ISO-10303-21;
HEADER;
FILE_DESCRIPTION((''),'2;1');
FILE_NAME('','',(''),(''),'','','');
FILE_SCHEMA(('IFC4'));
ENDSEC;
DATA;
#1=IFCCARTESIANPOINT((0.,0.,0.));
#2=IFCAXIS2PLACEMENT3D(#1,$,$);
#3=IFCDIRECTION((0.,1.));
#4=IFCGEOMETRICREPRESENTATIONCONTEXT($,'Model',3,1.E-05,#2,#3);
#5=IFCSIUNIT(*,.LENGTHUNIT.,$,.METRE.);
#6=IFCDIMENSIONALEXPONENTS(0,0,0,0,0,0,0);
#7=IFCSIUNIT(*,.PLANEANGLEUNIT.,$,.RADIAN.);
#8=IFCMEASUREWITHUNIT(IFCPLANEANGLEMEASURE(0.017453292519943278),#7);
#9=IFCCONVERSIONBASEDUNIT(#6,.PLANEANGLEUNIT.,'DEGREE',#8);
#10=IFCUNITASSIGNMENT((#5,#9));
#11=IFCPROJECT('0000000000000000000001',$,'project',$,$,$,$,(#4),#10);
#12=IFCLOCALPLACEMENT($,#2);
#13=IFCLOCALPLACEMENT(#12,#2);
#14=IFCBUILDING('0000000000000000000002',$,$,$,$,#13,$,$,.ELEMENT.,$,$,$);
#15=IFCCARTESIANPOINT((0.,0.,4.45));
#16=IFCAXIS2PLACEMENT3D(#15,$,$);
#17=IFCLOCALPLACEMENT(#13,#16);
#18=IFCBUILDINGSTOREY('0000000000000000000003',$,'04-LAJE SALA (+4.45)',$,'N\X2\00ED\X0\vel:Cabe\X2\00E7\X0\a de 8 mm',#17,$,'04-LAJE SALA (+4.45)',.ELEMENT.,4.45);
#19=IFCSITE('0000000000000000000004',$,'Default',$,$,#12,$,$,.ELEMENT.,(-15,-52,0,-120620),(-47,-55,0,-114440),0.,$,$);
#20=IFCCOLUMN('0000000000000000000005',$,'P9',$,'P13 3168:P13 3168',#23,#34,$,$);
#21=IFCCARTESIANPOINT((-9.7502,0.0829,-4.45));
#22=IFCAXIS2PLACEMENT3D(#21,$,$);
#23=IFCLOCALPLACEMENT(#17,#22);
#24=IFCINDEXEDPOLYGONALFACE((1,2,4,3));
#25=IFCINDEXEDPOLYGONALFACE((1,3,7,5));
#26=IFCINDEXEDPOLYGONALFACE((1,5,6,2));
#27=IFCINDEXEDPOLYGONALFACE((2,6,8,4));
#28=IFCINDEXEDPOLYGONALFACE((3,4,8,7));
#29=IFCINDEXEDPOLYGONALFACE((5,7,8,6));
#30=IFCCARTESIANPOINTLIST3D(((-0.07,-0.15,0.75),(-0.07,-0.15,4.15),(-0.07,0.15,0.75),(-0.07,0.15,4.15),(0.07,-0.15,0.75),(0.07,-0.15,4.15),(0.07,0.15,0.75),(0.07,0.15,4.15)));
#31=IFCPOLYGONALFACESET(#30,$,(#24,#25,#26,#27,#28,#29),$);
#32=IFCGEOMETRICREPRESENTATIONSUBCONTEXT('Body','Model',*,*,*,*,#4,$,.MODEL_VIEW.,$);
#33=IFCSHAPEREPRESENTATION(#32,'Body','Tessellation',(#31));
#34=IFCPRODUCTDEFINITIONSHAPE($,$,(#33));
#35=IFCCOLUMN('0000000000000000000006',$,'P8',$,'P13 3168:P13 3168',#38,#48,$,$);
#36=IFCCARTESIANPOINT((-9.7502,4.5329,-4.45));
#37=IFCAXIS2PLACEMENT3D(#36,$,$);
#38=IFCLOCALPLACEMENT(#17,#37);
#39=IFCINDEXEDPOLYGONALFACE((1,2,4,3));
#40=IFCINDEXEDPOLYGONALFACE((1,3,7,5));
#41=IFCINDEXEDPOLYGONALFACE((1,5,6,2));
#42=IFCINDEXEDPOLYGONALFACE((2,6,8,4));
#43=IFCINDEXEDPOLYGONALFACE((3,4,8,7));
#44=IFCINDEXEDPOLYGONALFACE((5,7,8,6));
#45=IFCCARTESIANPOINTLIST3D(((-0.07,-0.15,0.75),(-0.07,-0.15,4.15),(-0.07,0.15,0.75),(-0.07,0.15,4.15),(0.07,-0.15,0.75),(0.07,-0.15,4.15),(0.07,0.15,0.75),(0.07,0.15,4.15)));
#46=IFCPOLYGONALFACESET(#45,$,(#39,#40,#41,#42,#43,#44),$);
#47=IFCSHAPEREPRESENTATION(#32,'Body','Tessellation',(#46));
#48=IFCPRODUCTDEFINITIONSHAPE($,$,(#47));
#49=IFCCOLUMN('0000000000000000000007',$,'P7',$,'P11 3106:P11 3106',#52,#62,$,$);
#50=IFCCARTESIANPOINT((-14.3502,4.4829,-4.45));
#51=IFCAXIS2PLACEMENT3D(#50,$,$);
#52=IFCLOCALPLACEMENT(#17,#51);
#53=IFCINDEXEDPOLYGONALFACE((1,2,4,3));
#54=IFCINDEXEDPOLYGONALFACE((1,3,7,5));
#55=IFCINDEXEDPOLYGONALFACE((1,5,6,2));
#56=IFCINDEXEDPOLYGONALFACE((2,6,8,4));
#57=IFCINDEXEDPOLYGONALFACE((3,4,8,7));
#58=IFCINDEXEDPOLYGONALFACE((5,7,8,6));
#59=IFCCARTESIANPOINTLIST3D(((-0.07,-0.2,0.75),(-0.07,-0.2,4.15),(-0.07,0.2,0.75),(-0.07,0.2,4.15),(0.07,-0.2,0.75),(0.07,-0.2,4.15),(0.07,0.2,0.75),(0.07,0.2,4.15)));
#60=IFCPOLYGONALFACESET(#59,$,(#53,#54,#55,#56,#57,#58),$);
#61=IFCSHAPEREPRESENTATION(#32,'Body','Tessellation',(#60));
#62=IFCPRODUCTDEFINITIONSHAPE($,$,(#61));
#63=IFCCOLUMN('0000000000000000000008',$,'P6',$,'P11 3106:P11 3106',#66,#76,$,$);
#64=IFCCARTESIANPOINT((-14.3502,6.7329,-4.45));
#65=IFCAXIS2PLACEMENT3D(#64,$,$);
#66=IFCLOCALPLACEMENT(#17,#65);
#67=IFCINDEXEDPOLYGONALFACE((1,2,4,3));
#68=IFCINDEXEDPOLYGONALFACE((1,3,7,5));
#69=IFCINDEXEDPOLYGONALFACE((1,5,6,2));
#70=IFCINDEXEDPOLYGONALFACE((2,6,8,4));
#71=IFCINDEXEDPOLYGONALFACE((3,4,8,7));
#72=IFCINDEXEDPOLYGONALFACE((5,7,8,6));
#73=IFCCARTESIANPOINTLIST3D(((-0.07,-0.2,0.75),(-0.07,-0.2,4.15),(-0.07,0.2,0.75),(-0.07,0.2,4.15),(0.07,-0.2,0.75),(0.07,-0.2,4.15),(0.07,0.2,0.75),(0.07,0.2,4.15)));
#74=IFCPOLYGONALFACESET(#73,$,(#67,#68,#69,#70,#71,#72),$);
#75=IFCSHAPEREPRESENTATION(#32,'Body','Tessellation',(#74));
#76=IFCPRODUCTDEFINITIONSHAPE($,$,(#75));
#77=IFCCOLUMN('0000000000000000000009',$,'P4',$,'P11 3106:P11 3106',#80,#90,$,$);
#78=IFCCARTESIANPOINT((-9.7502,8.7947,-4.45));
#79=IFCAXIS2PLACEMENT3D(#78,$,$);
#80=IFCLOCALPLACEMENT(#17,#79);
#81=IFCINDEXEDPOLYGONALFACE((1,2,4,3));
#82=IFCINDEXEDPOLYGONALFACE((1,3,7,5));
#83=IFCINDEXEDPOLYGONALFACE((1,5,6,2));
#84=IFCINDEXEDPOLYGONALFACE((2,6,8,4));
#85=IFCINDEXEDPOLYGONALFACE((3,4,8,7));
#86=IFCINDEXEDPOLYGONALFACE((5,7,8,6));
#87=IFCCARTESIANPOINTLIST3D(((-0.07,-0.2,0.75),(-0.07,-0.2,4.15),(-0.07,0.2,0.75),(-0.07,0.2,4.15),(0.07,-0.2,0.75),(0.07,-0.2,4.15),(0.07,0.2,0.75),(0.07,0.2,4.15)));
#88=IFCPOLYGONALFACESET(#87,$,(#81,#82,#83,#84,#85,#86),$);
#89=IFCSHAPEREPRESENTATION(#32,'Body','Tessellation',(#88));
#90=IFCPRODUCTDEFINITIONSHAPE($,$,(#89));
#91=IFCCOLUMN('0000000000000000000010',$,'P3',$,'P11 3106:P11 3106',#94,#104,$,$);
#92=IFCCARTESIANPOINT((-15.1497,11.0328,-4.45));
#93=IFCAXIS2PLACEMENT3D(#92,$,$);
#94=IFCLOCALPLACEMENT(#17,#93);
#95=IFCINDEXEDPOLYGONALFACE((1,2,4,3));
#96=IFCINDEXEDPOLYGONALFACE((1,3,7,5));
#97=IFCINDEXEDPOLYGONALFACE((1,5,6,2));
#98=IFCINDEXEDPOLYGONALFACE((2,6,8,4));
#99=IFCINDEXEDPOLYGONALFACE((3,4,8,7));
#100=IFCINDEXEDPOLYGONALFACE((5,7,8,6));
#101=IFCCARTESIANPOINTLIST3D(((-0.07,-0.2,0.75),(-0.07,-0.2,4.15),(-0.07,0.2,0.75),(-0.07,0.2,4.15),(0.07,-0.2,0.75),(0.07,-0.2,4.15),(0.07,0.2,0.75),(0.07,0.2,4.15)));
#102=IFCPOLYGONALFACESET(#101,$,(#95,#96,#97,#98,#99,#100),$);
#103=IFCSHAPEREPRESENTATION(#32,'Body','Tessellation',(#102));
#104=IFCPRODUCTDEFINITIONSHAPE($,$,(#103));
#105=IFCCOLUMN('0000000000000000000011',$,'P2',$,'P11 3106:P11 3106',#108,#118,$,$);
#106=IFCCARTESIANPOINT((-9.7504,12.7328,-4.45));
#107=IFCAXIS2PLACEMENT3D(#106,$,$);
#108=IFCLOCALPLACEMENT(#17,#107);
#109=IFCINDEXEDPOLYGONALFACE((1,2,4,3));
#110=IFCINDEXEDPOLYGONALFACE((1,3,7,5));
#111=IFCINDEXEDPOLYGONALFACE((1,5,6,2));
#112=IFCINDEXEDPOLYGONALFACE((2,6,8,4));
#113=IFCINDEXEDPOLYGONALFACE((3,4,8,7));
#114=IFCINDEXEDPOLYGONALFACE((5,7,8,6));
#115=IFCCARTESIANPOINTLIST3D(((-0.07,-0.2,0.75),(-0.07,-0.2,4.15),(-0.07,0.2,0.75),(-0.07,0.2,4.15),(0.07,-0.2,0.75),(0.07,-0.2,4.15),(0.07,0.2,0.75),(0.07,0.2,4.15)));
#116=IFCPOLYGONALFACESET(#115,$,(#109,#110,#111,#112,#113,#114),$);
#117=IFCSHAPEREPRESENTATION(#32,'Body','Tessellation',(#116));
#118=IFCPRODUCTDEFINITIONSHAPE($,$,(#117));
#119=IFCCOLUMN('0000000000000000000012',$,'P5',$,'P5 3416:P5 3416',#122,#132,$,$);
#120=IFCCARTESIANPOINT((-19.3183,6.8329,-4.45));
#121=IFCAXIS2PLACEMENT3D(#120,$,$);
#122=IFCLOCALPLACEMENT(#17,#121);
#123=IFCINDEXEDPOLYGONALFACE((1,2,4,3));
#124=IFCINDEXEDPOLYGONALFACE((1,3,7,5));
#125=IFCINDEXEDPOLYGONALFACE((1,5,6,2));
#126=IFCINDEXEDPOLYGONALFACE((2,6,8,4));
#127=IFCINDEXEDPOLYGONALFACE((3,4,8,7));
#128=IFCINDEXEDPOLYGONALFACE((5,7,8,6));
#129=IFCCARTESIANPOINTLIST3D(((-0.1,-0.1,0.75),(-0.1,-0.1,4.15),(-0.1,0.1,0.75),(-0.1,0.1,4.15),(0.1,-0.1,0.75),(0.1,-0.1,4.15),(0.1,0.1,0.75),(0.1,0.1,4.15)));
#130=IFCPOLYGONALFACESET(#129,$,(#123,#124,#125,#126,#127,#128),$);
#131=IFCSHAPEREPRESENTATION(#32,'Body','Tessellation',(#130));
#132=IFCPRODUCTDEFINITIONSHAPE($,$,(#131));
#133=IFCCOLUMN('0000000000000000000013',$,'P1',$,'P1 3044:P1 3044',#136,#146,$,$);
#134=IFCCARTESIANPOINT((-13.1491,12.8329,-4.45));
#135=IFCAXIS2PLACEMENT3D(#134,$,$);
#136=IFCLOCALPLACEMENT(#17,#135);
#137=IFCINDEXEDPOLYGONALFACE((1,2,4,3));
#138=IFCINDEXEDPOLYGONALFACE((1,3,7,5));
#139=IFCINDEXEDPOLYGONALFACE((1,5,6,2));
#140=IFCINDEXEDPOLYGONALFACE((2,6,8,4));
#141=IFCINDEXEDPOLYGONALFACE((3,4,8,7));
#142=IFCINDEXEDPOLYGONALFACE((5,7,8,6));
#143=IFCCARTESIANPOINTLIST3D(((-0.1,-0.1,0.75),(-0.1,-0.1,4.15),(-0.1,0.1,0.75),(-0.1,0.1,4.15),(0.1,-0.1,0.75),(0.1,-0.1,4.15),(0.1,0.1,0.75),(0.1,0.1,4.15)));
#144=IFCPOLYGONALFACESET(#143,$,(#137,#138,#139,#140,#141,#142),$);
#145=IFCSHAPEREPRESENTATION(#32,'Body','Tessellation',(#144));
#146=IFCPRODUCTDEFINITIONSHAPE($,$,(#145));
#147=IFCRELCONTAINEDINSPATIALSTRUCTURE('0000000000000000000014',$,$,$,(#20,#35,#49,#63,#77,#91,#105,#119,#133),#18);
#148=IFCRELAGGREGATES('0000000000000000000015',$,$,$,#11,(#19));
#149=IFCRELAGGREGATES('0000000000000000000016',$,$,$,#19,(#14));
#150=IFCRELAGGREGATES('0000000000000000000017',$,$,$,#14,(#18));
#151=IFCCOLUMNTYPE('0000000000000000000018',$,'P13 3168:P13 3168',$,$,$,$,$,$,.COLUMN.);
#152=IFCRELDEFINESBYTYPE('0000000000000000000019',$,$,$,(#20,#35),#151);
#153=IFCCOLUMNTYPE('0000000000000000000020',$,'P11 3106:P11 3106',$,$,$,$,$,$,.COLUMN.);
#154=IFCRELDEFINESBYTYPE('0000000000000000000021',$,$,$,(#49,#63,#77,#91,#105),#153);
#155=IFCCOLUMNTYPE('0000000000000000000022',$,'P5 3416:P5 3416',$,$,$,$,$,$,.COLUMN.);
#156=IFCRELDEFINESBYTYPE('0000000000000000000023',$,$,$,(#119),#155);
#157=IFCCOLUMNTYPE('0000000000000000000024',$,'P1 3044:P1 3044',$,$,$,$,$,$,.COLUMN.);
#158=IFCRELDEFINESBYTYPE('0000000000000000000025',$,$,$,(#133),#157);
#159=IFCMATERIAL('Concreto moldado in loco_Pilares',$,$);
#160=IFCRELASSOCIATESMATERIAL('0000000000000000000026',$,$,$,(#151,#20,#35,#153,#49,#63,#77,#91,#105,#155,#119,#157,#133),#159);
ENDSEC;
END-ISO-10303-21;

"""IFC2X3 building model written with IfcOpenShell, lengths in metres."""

from ifc_helpers import new_model, entity, si_unit, converted_unit, direction, frame, origin, origin_2d_with_axis, place, context, subcontext, project, spatial, rectangle, extrude, source, transform, mapped, material, type_object, type_shapes, element, save


model = new_model("IFC2X3")

# Units and contexts
model_context = context("Model", 3, precision=1e-05, world=origin(), true_north=direction((0.0, 1.0)))
body_context = subcontext(model_context, "Body", "Model", "MODEL_VIEW")
ifc_project = project(units=[si_unit("LENGTHUNIT", "METRE"), converted_unit("PLANEANGLEUNIT", "DEGREE", entity("IfcPlaneAngleMeasure", 0.017453292519943278), si_unit("PLANEANGLEUNIT", "RADIAN"), dimensions=[0, 0, 0, 0, 0, 0, 0])], contexts=[model_context])

# Site, building, storey
site_placement = place(None, origin())
site = spatial("IfcSite", under=ifc_project, at=site_placement, Name="Default", CompositionType="ELEMENT", RefLatitude=(-15, -52, 0, -120620), RefLongitude=(-47, -55, 0, -114440), RefElevation=0.0)
building_placement = place(site_placement, origin())
building = spatial("IfcBuilding", under=site, at=building_placement, CompositionType="ELEMENT")
storey_placement = place(building_placement, frame((0.0, 0.0, 4.45)))
storey = spatial("IfcBuildingStorey", under=building, at=storey_placement, Name="04-LAJE SALA (+4.45)", ObjectType="Nível:Cabeça de 8 mm", LongName="04-LAJE SALA (+4.45)", CompositionType="ELEMENT", Elevation=4.45)

# Columns
ifc_material_1 = material(Name="Concreto moldado in loco_Pilares")
column_type_1 = type_object("IfcColumnType", Name="P13 3168:P13 3168", PredefinedType="COLUMN", material=ifc_material_1)
shared_shape_1 = source(origin(), body_context, "Body", "SweptSolid", [
    extrude(rectangle(XDim=0.3, YDim=0.14, at=origin_2d_with_axis()), frame((0.0, 0.0, 0.75), z_axis=(0.0, 0.0, 1.0), x_axis=(0.0, -1.0, 0.0)), (0.0, 0.0, 1.0), 3.4),
])
type_shapes(column_type_1, [shared_shape_1])
for number, where, name in (
    (1, (-9.7502, 0.0829, -4.45), "P9"),
    (2, (-9.7502, 4.5329, -4.45), "P8"),
):
    element("IfcColumn", number, at=place(storey_placement, frame(where)), inside=storey, type_object=column_type_1, material=ifc_material_1, Name=name, ObjectType="P13 3168:P13 3168", context=body_context, shape_type="MappedRepresentation", body=[
        mapped(shared_shape_1, transform((0.0, 0.0, 0.0), scale=1.0)),
    ])
column_type_2 = type_object("IfcColumnType", Name="P11 3106:P11 3106", PredefinedType="COLUMN", material=ifc_material_1)
shared_shape_2 = source(origin(), body_context, "Body", "SweptSolid", [
    extrude(rectangle(XDim=0.4, YDim=0.14, at=origin_2d_with_axis()), frame((0.0, 0.0, 0.75), z_axis=(0.0, 0.0, 1.0), x_axis=(0.0, -1.0, 0.0)), (0.0, 0.0, 1.0), 3.4),
])
type_shapes(column_type_2, [shared_shape_2])
for number, where, name in (
    (3, (-14.3502, 4.4829, -4.45), "P7"),
    (4, (-14.3502, 6.7329, -4.45), "P6"),
    (5, (-9.7502, 8.7947, -4.45), "P4"),
    (6, (-15.1497, 11.0328, -4.45), "P3"),
    (7, (-9.7504, 12.7328, -4.45), "P2"),
):
    element("IfcColumn", number, at=place(storey_placement, frame(where)), inside=storey, type_object=column_type_2, material=ifc_material_1, Name=name, ObjectType="P11 3106:P11 3106", context=body_context, shape_type="MappedRepresentation", body=[
        mapped(shared_shape_2, transform((0.0, 0.0, 0.0), scale=1.0)),
    ])
column_type_3 = type_object("IfcColumnType", Name="P5 3416:P5 3416", PredefinedType="COLUMN", material=ifc_material_1)
shared_shape_3 = source(origin(), body_context, "Body", "SweptSolid", [
    extrude(rectangle(XDim=0.2, YDim=0.2, at=origin_2d_with_axis()), frame((0.0, 0.0, 0.75), z_axis=(0.0, 0.0, 1.0), x_axis=(0.0, -1.0, 0.0)), (0.0, 0.0, 1.0), 3.4),
])
type_shapes(column_type_3, [shared_shape_3])
column_1_placement = place(storey_placement, frame((-19.3183, 6.8329, -4.45)))
element("IfcColumn", 8, at=column_1_placement, inside=storey, type_object=column_type_3, material=ifc_material_1, Name="P5", ObjectType="P5 3416:P5 3416", context=body_context, shape_type="MappedRepresentation", body=[
    mapped(shared_shape_3, transform((0.0, 0.0, 0.0), scale=1.0)),
])
column_type_4 = type_object("IfcColumnType", Name="P1 3044:P1 3044", PredefinedType="COLUMN", material=ifc_material_1)
shared_shape_4 = source(origin(), body_context, "Body", "SweptSolid", [
    extrude(rectangle(XDim=0.2, YDim=0.2, at=origin_2d_with_axis()), frame((0.0, 0.0, 0.75), z_axis=(0.0, 0.0, 1.0), x_axis=(0.0, 1.0, 0.0)), (0.0, 0.0, 1.0), 3.4),
])
type_shapes(column_type_4, [shared_shape_4])
column_2_placement = place(storey_placement, frame((-13.1491, 12.8329, -4.45)))
element("IfcColumn", 9, at=column_2_placement, inside=storey, type_object=column_type_4, material=ifc_material_1, Name="P1", ObjectType="P1 3044:P1 3044", context=body_context, shape_type="MappedRepresentation", body=[
    mapped(shared_shape_4, transform((0.0, 0.0, 0.0), scale=1.0)),
])

save(model, "model.ifc")
